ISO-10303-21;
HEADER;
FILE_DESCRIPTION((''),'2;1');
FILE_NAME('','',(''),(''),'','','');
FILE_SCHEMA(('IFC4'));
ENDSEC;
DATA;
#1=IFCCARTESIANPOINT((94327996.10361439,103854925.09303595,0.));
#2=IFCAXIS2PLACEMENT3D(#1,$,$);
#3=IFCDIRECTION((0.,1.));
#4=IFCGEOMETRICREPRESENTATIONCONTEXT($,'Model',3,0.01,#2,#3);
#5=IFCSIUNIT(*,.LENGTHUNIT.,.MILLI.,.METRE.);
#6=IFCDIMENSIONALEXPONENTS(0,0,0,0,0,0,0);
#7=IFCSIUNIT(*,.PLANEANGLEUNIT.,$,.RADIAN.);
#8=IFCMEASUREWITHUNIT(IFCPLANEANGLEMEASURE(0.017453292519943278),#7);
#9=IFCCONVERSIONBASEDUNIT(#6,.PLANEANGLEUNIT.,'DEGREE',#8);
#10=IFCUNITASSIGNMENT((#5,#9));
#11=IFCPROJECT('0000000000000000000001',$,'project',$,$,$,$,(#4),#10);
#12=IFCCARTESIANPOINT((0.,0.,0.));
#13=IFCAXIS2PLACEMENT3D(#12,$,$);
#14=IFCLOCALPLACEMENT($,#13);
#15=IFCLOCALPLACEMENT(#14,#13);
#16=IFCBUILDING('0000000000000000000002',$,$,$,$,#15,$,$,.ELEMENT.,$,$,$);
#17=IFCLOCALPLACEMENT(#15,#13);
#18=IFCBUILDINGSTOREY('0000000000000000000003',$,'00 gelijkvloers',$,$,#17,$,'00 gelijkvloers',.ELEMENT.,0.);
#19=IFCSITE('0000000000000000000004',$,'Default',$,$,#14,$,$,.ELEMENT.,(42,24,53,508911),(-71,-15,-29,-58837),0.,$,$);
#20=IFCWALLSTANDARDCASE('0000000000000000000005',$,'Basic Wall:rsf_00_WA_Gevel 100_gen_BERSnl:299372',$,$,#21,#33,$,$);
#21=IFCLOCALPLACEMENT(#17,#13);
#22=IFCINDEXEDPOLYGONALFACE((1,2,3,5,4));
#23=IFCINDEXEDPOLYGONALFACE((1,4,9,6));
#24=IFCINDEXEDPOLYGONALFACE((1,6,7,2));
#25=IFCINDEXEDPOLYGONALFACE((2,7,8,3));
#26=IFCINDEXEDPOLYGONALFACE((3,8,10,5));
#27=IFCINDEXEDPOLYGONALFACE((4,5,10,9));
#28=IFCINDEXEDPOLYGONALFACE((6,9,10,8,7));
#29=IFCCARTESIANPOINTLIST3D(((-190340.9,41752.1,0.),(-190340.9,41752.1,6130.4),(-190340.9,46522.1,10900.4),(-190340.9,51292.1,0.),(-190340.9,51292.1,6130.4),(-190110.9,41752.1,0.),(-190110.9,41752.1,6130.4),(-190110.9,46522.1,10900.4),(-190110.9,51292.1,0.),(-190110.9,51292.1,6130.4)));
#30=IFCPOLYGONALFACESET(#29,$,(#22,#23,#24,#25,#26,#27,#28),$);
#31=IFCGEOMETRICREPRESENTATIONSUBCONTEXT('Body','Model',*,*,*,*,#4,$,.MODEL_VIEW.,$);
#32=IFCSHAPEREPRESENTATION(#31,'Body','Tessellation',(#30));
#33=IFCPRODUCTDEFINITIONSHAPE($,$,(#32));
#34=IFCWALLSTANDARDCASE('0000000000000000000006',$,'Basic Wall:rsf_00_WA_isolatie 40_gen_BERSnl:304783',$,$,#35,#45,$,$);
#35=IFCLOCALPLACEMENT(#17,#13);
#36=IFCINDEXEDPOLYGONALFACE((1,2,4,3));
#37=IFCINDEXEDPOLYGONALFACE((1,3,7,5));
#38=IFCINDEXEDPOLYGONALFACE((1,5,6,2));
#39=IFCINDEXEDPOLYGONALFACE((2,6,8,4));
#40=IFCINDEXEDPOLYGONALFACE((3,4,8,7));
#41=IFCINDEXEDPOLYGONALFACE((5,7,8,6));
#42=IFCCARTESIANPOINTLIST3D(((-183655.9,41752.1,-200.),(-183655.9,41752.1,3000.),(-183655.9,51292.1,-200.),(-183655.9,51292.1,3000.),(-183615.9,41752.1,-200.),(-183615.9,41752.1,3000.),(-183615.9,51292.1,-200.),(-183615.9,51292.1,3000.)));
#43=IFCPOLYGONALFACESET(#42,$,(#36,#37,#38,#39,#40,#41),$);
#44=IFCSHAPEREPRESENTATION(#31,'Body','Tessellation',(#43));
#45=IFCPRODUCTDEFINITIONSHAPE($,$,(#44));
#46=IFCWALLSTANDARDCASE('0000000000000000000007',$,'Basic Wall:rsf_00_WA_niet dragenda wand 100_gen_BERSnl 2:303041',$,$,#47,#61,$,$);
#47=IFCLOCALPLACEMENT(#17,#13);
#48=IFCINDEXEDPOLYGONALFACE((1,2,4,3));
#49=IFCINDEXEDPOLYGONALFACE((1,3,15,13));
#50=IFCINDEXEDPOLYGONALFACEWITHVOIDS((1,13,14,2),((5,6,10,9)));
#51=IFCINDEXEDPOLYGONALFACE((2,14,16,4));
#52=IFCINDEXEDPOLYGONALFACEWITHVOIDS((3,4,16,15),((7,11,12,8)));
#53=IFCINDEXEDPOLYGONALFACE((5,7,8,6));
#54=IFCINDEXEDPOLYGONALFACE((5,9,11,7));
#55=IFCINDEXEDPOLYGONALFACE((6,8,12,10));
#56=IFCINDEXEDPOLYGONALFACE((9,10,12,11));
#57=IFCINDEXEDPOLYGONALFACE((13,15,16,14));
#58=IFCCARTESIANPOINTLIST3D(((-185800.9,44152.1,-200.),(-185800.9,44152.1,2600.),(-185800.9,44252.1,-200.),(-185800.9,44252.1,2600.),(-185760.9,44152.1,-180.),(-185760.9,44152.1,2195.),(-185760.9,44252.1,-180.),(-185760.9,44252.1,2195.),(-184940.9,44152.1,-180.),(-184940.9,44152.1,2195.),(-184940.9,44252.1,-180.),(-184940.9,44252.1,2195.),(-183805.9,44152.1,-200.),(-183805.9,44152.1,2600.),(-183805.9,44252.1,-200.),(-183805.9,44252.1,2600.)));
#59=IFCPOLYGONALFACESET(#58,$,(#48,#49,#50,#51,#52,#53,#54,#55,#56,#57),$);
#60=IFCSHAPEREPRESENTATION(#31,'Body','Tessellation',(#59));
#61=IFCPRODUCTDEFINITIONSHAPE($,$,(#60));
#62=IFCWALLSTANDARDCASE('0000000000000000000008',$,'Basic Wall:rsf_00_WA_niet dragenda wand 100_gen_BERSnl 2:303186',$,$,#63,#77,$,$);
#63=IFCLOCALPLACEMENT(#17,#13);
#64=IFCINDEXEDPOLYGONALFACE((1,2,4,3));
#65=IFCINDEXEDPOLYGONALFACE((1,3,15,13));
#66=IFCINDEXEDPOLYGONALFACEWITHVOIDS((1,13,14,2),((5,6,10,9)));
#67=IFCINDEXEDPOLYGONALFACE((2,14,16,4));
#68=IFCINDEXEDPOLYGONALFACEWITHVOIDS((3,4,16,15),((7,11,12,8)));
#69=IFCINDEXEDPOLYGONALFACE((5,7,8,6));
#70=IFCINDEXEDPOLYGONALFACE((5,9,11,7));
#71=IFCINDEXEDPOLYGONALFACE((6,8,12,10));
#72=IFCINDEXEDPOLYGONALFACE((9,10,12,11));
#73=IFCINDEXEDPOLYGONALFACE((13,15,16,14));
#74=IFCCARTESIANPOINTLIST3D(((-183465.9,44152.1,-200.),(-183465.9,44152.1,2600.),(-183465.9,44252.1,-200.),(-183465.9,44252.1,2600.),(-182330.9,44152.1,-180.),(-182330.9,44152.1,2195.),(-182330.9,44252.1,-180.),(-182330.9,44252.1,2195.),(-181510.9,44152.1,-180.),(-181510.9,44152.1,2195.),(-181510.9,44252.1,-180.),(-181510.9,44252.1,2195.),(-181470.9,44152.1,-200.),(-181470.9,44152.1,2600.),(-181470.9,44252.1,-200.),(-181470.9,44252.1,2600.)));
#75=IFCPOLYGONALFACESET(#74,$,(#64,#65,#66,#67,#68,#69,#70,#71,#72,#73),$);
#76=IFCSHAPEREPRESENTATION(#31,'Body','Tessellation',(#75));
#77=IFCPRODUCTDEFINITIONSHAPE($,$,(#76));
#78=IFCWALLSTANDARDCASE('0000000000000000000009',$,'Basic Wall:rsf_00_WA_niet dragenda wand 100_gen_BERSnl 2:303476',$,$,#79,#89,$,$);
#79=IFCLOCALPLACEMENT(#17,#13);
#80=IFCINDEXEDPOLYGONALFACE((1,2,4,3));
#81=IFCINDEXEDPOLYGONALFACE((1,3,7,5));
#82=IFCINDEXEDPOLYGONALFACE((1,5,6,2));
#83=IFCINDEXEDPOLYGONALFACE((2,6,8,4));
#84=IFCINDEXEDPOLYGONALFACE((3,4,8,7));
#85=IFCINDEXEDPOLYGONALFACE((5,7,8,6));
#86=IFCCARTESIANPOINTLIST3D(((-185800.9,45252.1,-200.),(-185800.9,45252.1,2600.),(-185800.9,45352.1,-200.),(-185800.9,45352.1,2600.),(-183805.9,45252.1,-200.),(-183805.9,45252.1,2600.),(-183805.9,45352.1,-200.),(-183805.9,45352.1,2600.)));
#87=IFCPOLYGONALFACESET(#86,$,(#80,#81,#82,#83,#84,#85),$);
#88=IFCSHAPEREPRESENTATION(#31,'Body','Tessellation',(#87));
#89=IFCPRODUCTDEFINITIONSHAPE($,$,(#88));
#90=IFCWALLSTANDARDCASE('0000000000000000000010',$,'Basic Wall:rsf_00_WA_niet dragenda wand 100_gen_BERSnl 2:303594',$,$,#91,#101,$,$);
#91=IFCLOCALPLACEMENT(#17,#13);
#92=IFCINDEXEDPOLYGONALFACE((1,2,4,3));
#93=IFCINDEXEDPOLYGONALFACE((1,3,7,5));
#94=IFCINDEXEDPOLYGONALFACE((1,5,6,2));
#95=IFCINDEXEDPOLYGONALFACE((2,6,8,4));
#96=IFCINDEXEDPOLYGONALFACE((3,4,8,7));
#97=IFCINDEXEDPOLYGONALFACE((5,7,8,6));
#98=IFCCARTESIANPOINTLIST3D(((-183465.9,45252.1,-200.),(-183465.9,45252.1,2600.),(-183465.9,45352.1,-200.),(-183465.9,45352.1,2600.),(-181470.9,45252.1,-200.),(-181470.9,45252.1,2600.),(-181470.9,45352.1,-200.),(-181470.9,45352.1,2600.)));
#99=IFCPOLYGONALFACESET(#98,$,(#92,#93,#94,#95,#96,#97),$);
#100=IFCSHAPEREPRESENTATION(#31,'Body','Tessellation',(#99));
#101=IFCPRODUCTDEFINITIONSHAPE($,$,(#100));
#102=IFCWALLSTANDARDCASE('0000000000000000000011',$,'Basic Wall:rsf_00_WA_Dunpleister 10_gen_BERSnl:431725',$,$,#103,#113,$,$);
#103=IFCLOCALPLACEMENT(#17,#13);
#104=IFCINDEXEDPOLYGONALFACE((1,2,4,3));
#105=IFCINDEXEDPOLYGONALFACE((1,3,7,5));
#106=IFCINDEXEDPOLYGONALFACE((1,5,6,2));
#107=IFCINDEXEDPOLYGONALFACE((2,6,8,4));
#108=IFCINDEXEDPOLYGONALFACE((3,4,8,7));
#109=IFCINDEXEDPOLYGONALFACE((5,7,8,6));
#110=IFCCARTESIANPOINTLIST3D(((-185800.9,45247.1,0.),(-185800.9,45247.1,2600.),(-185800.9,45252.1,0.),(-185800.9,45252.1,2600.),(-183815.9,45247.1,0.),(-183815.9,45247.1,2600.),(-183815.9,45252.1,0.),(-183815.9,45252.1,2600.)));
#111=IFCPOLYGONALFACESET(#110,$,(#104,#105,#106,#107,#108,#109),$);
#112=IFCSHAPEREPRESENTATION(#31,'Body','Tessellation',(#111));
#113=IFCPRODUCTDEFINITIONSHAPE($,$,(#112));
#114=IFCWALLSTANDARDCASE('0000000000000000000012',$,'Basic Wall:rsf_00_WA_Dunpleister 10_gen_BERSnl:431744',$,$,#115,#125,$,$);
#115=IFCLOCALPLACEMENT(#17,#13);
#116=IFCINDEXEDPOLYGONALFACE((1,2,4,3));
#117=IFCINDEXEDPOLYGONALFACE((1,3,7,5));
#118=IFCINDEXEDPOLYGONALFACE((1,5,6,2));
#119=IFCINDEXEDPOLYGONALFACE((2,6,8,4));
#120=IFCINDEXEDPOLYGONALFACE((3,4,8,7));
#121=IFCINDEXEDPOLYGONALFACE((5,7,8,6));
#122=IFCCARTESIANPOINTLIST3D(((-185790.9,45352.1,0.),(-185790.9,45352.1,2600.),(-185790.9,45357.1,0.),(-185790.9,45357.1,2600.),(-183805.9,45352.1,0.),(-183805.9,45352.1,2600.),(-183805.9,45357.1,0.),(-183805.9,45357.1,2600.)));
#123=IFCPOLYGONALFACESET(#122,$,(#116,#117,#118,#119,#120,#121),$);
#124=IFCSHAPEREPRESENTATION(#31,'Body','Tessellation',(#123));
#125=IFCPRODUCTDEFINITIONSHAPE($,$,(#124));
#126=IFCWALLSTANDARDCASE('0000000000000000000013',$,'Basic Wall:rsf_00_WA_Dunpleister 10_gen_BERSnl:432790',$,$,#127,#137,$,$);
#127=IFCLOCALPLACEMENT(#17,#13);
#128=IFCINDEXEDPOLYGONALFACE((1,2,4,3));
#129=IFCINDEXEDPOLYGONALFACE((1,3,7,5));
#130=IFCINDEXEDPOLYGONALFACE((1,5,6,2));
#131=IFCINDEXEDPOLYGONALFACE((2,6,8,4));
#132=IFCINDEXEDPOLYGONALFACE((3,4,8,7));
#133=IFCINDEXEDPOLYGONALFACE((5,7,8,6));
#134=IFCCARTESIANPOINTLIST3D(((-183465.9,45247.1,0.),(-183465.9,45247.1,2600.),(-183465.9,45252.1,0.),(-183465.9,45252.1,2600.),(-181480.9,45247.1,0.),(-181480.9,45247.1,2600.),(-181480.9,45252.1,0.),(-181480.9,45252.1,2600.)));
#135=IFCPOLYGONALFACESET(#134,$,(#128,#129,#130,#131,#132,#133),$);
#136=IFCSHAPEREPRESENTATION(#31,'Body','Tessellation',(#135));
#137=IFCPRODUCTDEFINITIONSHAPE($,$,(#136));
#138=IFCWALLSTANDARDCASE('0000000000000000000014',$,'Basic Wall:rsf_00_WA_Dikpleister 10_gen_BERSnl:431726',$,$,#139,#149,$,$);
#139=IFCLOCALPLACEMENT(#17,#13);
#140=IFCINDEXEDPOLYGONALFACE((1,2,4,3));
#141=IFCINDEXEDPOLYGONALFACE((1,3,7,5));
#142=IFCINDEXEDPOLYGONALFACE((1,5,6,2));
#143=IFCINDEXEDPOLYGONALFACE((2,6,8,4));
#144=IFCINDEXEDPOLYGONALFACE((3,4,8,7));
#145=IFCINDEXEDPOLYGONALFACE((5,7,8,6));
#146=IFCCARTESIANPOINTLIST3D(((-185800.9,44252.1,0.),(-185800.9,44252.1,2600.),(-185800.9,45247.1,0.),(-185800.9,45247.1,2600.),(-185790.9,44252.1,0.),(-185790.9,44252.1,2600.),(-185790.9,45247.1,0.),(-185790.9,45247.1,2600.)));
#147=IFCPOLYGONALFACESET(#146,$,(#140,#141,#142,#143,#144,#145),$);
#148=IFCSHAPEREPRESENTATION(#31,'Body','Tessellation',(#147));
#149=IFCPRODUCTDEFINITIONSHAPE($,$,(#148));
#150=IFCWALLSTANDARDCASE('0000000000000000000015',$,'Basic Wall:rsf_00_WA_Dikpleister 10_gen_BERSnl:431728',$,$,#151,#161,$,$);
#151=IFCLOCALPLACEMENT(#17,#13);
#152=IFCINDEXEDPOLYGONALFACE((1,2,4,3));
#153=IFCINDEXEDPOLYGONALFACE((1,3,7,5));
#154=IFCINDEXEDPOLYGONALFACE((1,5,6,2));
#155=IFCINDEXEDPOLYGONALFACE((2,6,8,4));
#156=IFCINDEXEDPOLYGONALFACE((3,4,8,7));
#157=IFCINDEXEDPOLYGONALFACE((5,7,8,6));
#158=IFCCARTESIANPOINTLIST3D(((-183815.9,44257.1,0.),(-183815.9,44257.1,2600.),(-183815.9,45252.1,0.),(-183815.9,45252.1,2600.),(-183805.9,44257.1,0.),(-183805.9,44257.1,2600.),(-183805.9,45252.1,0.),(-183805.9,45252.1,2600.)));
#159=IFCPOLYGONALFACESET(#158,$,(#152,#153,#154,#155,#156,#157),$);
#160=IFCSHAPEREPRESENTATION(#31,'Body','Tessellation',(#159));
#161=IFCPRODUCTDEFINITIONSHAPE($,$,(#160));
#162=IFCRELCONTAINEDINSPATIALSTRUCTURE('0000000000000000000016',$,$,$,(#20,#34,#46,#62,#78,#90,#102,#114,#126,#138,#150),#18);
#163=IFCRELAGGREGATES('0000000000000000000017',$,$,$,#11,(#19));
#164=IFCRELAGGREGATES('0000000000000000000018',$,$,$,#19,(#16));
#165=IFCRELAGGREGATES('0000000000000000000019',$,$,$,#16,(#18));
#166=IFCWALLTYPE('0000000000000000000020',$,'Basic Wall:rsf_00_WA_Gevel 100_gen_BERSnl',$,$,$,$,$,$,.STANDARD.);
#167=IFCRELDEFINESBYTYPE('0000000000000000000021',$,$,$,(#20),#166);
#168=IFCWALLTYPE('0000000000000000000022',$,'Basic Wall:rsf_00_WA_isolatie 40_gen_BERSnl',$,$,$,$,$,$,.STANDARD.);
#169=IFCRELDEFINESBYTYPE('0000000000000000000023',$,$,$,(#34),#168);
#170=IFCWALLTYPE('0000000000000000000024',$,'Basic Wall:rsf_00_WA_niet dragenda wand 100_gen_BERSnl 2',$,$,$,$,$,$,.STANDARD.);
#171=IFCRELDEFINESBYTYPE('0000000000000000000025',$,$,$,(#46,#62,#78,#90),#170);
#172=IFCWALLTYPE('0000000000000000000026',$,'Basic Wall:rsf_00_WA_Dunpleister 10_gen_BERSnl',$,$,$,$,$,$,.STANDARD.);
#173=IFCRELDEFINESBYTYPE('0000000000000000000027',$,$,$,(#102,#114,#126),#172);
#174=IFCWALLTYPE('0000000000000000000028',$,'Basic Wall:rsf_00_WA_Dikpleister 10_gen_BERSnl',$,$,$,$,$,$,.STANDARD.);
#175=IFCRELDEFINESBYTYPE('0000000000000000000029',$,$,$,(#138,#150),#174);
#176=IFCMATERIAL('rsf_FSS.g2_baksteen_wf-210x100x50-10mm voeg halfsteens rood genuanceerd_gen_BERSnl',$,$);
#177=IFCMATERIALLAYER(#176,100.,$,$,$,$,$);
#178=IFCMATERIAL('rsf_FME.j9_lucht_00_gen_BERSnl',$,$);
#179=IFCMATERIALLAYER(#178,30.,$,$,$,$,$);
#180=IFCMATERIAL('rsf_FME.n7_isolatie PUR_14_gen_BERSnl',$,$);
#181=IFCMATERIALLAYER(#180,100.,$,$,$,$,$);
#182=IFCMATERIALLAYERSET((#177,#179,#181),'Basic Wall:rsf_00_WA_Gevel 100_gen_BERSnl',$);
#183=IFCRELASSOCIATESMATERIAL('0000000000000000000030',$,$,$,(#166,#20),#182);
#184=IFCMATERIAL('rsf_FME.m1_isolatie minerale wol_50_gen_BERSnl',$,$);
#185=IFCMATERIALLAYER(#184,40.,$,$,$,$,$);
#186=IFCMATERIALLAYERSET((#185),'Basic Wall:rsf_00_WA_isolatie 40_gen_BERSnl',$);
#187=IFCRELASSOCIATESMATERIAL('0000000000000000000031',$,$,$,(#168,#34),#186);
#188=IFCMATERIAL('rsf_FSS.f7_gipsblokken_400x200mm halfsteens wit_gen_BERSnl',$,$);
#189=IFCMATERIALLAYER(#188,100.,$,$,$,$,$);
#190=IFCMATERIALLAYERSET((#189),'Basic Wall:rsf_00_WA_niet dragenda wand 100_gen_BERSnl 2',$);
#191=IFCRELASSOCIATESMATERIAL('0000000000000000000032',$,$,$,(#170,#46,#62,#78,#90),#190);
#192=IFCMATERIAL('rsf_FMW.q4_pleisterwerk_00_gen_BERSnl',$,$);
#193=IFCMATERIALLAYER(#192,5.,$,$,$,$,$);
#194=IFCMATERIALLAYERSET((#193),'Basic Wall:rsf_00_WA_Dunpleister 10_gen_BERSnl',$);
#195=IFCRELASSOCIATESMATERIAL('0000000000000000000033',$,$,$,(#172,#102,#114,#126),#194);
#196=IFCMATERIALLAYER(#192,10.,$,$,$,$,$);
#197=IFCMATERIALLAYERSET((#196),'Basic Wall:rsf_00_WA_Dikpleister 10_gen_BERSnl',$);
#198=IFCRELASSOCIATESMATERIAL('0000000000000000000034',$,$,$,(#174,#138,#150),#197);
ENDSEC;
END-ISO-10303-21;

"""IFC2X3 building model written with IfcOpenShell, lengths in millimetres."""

from ifc_helpers import new_model, entity, si_unit, converted_unit, direction, frame, frame_2d, origin, place, context, subcontext, project, spatial, polyline, rectangle, extrude, clip, bounded_halfspace, material, layer, layer_set, layer_usage, type_object, element, save


model = new_model("IFC2X3")

# Units and contexts
model_context = context("Model", 3, precision=0.01, world=frame((94327996.10361439, 103854925.09303595, 0.0)), true_north=direction((0.0, 1.0)))
body_context = subcontext(model_context, "Body", "Model", "MODEL_VIEW")
ifc_project = project(units=[si_unit("LENGTHUNIT", "METRE", prefix="MILLI"), converted_unit("PLANEANGLEUNIT", "DEGREE", entity("IfcPlaneAngleMeasure", 0.017453292519943278), si_unit("PLANEANGLEUNIT", "RADIAN"), dimensions=[0, 0, 0, 0, 0, 0, 0])], contexts=[model_context])

# Site, building, storey
site_placement = place(None, origin())
site = spatial("IfcSite", under=ifc_project, at=site_placement, Name="Default", CompositionType="ELEMENT", RefLatitude=(42, 24, 53, 508911), RefLongitude=(-71, -15, -29, -58837), RefElevation=0.0)
building_placement = place(site_placement, origin())
building = spatial("IfcBuilding", under=site, at=building_placement, CompositionType="ELEMENT")
storey_placement = place(building_placement, origin())
storey = spatial("IfcBuildingStorey", under=building, at=storey_placement, Name="00 gelijkvloers", LongName="00 gelijkvloers", CompositionType="ELEMENT", Elevation=0.0)

# Walls
ifc_material_1 = material(Name="rsf_FSS.g2_baksteen_wf-210x100x50-10mm voeg halfsteens rood genuanceerd_gen_BERSnl")
ifc_layer_1 = layer(ifc_material_1, 100.0)
ifc_material_2 = material(Name="rsf_FME.j9_lucht_00_gen_BERSnl")
ifc_layer_2 = layer(ifc_material_2, 30.0)
ifc_material_3 = material(Name="rsf_FME.n7_isolatie PUR_14_gen_BERSnl")
ifc_layer_3 = layer(ifc_material_3, 100.0)
ifc_layer_set_1 = layer_set([ifc_layer_1, ifc_layer_2, ifc_layer_3], Name="Basic Wall:rsf_00_WA_Gevel 100_gen_BERSnl")
ifc_layer_usage_1 = layer_usage(ifc_layer_set_1, "AXIS2", "NEGATIVE", 115.0)
wall_type_1 = type_object("IfcWallType", Name="Basic Wall:rsf_00_WA_Gevel 100_gen_BERSnl", PredefinedType="STANDARD", material=ifc_layer_set_1)
wall_1_placement = place(storey_placement, frame((-190225.9, 41752.1, 0.0), z_axis=(0.0, 0.0, 1.0), x_axis=(0.0, 1.0, 0.0)))
element("IfcWallStandardCase", 1, at=wall_1_placement, inside=storey, type_object=wall_type_1, material=ifc_layer_usage_1, Name="Basic Wall:rsf_00_WA_Gevel 100_gen_BERSnl:299372", context=body_context, shape_type="Clipping", body=[
    clip(clip(extrude(rectangle(XDim=9540.0, YDim=230.0, at=frame_2d((4770.0, 0.0), x_axis=(-1.0, 0.0))), origin(), (0.0, 0.0, 1.0), 10900.4), bounded_halfspace(frame((4770.0, -115.0, 10900.4), z_axis=(-0.707107, 0.0, -0.707107), x_axis=(0.0, -1.0, 0.0)), True, frame((4770.0, -115.0, 10900.4)), polyline([(0.0, 0.0), (4770.0, 0.0), (4770.0, 230.0), (0.0, 230.0), (0.0, 0.0)]))), bounded_halfspace(frame((0.0, -115.0, 6130.4), z_axis=(0.707107, 0.0, -0.707107), x_axis=(0.0, -1.0, 0.0)), True, frame((0.0, -115.0, 6130.4)), polyline([(0.0, 0.0), (4770.0, 0.0), (4770.0, 230.0), (0.0, 230.0), (0.0, 0.0)]))),
])
ifc_material_4 = material(Name="rsf_FME.m1_isolatie minerale wol_50_gen_BERSnl")
ifc_layer_4 = layer(ifc_material_4, 40.0)
ifc_layer_set_2 = layer_set([ifc_layer_4], Name="Basic Wall:rsf_00_WA_isolatie 40_gen_BERSnl")
ifc_layer_usage_2 = layer_usage(ifc_layer_set_2, "AXIS2", "POSITIVE", -20.0)
wall_type_2 = type_object("IfcWallType", Name="Basic Wall:rsf_00_WA_isolatie 40_gen_BERSnl", PredefinedType="STANDARD", material=ifc_layer_set_2)
wall_2_placement = place(storey_placement, frame((-183635.9, 41752.1, -200.0), z_axis=(0.0, 0.0, 1.0), x_axis=(0.0, 1.0, 0.0)))
element("IfcWallStandardCase", 2, at=wall_2_placement, inside=storey, type_object=wall_type_2, material=ifc_layer_usage_2, Name="Basic Wall:rsf_00_WA_isolatie 40_gen_BERSnl:304783", context=body_context, shape_type="SweptSolid", body=[
    extrude(rectangle(XDim=9540.0, YDim=40.0, at=frame_2d((4770.0, 0.0), x_axis=(-1.0, 0.0))), origin(), (0.0, 0.0, 1.0), 3200.0),
])

# Walls, openings
ifc_material_5 = material(Name="rsf_FSS.f7_gipsblokken_400x200mm halfsteens wit_gen_BERSnl")
ifc_layer_5 = layer(ifc_material_5, 100.0)
ifc_layer_set_3 = layer_set([ifc_layer_5], Name="Basic Wall:rsf_00_WA_niet dragenda wand 100_gen_BERSnl 2")
ifc_layer_usage_3 = layer_usage(ifc_layer_set_3, "AXIS2", "POSITIVE", -50.0)
wall_type_3 = type_object("IfcWallType", Name="Basic Wall:rsf_00_WA_niet dragenda wand 100_gen_BERSnl 2", PredefinedType="STANDARD", material=ifc_layer_set_3)
wall_3_placement = place(storey_placement, frame((-183805.9, 44202.1, -200.0), z_axis=(0.0, 0.0, 1.0), x_axis=(-1.0, 0.0, 0.0)))
wall_3 = element("IfcWallStandardCase", 3, at=wall_3_placement, inside=storey, type_object=wall_type_3, material=ifc_layer_usage_3, Name="Basic Wall:rsf_00_WA_niet dragenda wand 100_gen_BERSnl 2:303041", context=body_context, shape_type="SweptSolid", body=[
    extrude(rectangle(XDim=1995.0, YDim=100.0, at=frame_2d((997.5, 0.0), x_axis=(-1.0, 0.0))), origin(), (0.0, 0.0, 1.0), 2800.0),
])
opening_1_placement = place(wall_3_placement, frame((1135.0, -50.0, 20.0)))
element("IfcOpeningElement", 4, at=opening_1_placement, cuts=wall_3, ObjectType="Opening", context=body_context, shape_type="SweptSolid", body=[
    extrude(rectangle(XDim=2375.0, YDim=820.0, at=frame_2d((1187.5, 410.0), x_axis=(-1.0, 0.0))), frame((0.0, 0.0, 0.0), z_axis=(0.0, 1.0, 0.0), x_axis=(0.0, 0.0, 1.0)), (0.0, 0.0, 1.0), 100.0),
])
ifc_layer_usage_4 = layer_usage(ifc_layer_set_3, "AXIS2", "NEGATIVE", 50.0)
wall_4_placement = place(storey_placement, frame((-183465.9, 44202.1, -200.0)))
wall_4 = element("IfcWallStandardCase", 5, at=wall_4_placement, inside=storey, type_object=wall_type_3, material=ifc_layer_usage_4, Name="Basic Wall:rsf_00_WA_niet dragenda wand 100_gen_BERSnl 2:303186", context=body_context, shape_type="SweptSolid", body=[
    extrude(rectangle(XDim=1995.0, YDim=100.0, at=frame_2d((997.5, 0.0), x_axis=(-1.0, 0.0))), origin(), (0.0, 0.0, 1.0), 2800.0),
])
opening_2_placement = place(wall_4_placement, frame((1955.0, 50.0, 20.0)))
element("IfcOpeningElement", 6, at=opening_2_placement, cuts=wall_4, ObjectType="Opening", context=body_context, shape_type="SweptSolid", body=[
    extrude(rectangle(XDim=2375.0, YDim=820.0, at=frame_2d((1187.5, 410.0), x_axis=(-1.0, 0.0))), frame((0.0, 0.0, 0.0), z_axis=(0.0, -1.0, 0.0), x_axis=(0.0, 0.0, 1.0)), (0.0, 0.0, 1.0), 100.0),
])

# Walls
ifc_layer_usage_5 = layer_usage(ifc_layer_set_3, "AXIS2", "NEGATIVE", 50.0)
wall_5_placement = place(storey_placement, frame((-185800.9, 45302.1, -200.0)))
element("IfcWallStandardCase", 7, at=wall_5_placement, inside=storey, type_object=wall_type_3, material=ifc_layer_usage_5, Name="Basic Wall:rsf_00_WA_niet dragenda wand 100_gen_BERSnl 2:303476", context=body_context, shape_type="SweptSolid", body=[
    extrude(rectangle(XDim=1995.0, YDim=100.0, at=frame_2d((997.5, 0.0), x_axis=(-1.0, 0.0))), origin(), (0.0, 0.0, 1.0), 2800.0),
])
ifc_layer_usage_6 = layer_usage(ifc_layer_set_3, "AXIS2", "NEGATIVE", 50.0)
wall_6_placement = place(storey_placement, frame((-183465.9, 45302.1, -200.0)))
element("IfcWallStandardCase", 8, at=wall_6_placement, inside=storey, type_object=wall_type_3, material=ifc_layer_usage_6, Name="Basic Wall:rsf_00_WA_niet dragenda wand 100_gen_BERSnl 2:303594", context=body_context, shape_type="SweptSolid", body=[
    extrude(rectangle(XDim=1995.0, YDim=100.0, at=frame_2d((997.5, 0.0), x_axis=(-1.0, 0.0))), origin(), (0.0, 0.0, 1.0), 2800.0),
])
ifc_material_6 = material(Name="rsf_FMW.q4_pleisterwerk_00_gen_BERSnl")
ifc_layer_6 = layer(ifc_material_6, 5.0)
ifc_layer_set_4 = layer_set([ifc_layer_6], Name="Basic Wall:rsf_00_WA_Dunpleister 10_gen_BERSnl")
ifc_layer_usage_7 = layer_usage(ifc_layer_set_4, "AXIS2", "POSITIVE", -2.5)
wall_type_4 = type_object("IfcWallType", Name="Basic Wall:rsf_00_WA_Dunpleister 10_gen_BERSnl", PredefinedType="STANDARD", material=ifc_layer_set_4)
wall_7_placement = place(storey_placement, frame((-185800.9, 45249.6, 0.0)))
element("IfcWallStandardCase", 9, at=wall_7_placement, inside=storey, type_object=wall_type_4, material=ifc_layer_usage_7, Name="Basic Wall:rsf_00_WA_Dunpleister 10_gen_BERSnl:431725", context=body_context, shape_type="SweptSolid", body=[
    extrude(rectangle(XDim=1985.0, YDim=5.0, at=frame_2d((992.5, 0.0), x_axis=(-1.0, 0.0))), origin(), (0.0, 0.0, 1.0), 2600.0),
])

# Wall
ifc_layer_usage_8 = layer_usage(ifc_layer_set_4, "AXIS2", "POSITIVE", -2.5)
wall_8_placement = place(storey_placement, frame((-183805.9, 45354.6, 0.0), z_axis=(0.0, 0.0, 1.0), x_axis=(-1.0, 0.0, 0.0)))
element("IfcWallStandardCase", 10, at=wall_8_placement, inside=storey, type_object=wall_type_4, material=ifc_layer_usage_8, Name="Basic Wall:rsf_00_WA_Dunpleister 10_gen_BERSnl:431744", context=body_context, shape_type="SweptSolid", body=[
    extrude(rectangle(XDim=1985.0, YDim=5.0, at=frame_2d((992.5, 0.0), x_axis=(-1.0, 0.0))), origin(), (0.0, 0.0, 1.0), 2600.0),
])

# Walls
ifc_layer_usage_9 = layer_usage(ifc_layer_set_4, "AXIS2", "POSITIVE", -2.5)
wall_9_placement = place(storey_placement, frame((-183465.9, 45249.6, 0.0)))
element("IfcWallStandardCase", 11, at=wall_9_placement, inside=storey, type_object=wall_type_4, material=ifc_layer_usage_9, Name="Basic Wall:rsf_00_WA_Dunpleister 10_gen_BERSnl:432790", context=body_context, shape_type="SweptSolid", body=[
    extrude(rectangle(XDim=1985.0, YDim=5.0, at=frame_2d((992.5, 0.0), x_axis=(-1.0, 0.0))), origin(), (0.0, 0.0, 1.0), 2600.0),
])
ifc_layer_7 = layer(ifc_material_6, 10.0)
ifc_layer_set_5 = layer_set([ifc_layer_7], Name="Basic Wall:rsf_00_WA_Dikpleister 10_gen_BERSnl")
ifc_layer_usage_10 = layer_usage(ifc_layer_set_5, "AXIS2", "POSITIVE", -5.0)
wall_type_5 = type_object("IfcWallType", Name="Basic Wall:rsf_00_WA_Dikpleister 10_gen_BERSnl", PredefinedType="STANDARD", material=ifc_layer_set_5)
wall_10_placement = place(storey_placement, frame((-185795.9, 44252.1, 0.0), z_axis=(0.0, 0.0, 1.0), x_axis=(0.0, 1.0, 0.0)))
element("IfcWallStandardCase", 12, at=wall_10_placement, inside=storey, type_object=wall_type_5, material=ifc_layer_usage_10, Name="Basic Wall:rsf_00_WA_Dikpleister 10_gen_BERSnl:431726", context=body_context, shape_type="SweptSolid", body=[
    extrude(rectangle(XDim=995.0, YDim=10.0, at=frame_2d((497.5, 0.0), x_axis=(-1.0, 0.0))), origin(), (0.0, 0.0, 1.0), 2600.0),
])
ifc_layer_usage_11 = layer_usage(ifc_layer_set_5, "AXIS2", "POSITIVE", -5.0)
wall_11_placement = place(storey_placement, frame((-183810.9, 45252.1, 0.0), z_axis=(0.0, 0.0, 1.0), x_axis=(0.0, -1.0, 0.0)))
element("IfcWallStandardCase", 13, at=wall_11_placement, inside=storey, type_object=wall_type_5, material=ifc_layer_usage_11, Name="Basic Wall:rsf_00_WA_Dikpleister 10_gen_BERSnl:431728", context=body_context, shape_type="SweptSolid", body=[
    extrude(rectangle(XDim=995.0, YDim=10.0, at=frame_2d((497.5, 0.0), x_axis=(-1.0, 0.0))), origin(), (0.0, 0.0, 1.0), 2600.0),
])

save(model, "model.ifc")
